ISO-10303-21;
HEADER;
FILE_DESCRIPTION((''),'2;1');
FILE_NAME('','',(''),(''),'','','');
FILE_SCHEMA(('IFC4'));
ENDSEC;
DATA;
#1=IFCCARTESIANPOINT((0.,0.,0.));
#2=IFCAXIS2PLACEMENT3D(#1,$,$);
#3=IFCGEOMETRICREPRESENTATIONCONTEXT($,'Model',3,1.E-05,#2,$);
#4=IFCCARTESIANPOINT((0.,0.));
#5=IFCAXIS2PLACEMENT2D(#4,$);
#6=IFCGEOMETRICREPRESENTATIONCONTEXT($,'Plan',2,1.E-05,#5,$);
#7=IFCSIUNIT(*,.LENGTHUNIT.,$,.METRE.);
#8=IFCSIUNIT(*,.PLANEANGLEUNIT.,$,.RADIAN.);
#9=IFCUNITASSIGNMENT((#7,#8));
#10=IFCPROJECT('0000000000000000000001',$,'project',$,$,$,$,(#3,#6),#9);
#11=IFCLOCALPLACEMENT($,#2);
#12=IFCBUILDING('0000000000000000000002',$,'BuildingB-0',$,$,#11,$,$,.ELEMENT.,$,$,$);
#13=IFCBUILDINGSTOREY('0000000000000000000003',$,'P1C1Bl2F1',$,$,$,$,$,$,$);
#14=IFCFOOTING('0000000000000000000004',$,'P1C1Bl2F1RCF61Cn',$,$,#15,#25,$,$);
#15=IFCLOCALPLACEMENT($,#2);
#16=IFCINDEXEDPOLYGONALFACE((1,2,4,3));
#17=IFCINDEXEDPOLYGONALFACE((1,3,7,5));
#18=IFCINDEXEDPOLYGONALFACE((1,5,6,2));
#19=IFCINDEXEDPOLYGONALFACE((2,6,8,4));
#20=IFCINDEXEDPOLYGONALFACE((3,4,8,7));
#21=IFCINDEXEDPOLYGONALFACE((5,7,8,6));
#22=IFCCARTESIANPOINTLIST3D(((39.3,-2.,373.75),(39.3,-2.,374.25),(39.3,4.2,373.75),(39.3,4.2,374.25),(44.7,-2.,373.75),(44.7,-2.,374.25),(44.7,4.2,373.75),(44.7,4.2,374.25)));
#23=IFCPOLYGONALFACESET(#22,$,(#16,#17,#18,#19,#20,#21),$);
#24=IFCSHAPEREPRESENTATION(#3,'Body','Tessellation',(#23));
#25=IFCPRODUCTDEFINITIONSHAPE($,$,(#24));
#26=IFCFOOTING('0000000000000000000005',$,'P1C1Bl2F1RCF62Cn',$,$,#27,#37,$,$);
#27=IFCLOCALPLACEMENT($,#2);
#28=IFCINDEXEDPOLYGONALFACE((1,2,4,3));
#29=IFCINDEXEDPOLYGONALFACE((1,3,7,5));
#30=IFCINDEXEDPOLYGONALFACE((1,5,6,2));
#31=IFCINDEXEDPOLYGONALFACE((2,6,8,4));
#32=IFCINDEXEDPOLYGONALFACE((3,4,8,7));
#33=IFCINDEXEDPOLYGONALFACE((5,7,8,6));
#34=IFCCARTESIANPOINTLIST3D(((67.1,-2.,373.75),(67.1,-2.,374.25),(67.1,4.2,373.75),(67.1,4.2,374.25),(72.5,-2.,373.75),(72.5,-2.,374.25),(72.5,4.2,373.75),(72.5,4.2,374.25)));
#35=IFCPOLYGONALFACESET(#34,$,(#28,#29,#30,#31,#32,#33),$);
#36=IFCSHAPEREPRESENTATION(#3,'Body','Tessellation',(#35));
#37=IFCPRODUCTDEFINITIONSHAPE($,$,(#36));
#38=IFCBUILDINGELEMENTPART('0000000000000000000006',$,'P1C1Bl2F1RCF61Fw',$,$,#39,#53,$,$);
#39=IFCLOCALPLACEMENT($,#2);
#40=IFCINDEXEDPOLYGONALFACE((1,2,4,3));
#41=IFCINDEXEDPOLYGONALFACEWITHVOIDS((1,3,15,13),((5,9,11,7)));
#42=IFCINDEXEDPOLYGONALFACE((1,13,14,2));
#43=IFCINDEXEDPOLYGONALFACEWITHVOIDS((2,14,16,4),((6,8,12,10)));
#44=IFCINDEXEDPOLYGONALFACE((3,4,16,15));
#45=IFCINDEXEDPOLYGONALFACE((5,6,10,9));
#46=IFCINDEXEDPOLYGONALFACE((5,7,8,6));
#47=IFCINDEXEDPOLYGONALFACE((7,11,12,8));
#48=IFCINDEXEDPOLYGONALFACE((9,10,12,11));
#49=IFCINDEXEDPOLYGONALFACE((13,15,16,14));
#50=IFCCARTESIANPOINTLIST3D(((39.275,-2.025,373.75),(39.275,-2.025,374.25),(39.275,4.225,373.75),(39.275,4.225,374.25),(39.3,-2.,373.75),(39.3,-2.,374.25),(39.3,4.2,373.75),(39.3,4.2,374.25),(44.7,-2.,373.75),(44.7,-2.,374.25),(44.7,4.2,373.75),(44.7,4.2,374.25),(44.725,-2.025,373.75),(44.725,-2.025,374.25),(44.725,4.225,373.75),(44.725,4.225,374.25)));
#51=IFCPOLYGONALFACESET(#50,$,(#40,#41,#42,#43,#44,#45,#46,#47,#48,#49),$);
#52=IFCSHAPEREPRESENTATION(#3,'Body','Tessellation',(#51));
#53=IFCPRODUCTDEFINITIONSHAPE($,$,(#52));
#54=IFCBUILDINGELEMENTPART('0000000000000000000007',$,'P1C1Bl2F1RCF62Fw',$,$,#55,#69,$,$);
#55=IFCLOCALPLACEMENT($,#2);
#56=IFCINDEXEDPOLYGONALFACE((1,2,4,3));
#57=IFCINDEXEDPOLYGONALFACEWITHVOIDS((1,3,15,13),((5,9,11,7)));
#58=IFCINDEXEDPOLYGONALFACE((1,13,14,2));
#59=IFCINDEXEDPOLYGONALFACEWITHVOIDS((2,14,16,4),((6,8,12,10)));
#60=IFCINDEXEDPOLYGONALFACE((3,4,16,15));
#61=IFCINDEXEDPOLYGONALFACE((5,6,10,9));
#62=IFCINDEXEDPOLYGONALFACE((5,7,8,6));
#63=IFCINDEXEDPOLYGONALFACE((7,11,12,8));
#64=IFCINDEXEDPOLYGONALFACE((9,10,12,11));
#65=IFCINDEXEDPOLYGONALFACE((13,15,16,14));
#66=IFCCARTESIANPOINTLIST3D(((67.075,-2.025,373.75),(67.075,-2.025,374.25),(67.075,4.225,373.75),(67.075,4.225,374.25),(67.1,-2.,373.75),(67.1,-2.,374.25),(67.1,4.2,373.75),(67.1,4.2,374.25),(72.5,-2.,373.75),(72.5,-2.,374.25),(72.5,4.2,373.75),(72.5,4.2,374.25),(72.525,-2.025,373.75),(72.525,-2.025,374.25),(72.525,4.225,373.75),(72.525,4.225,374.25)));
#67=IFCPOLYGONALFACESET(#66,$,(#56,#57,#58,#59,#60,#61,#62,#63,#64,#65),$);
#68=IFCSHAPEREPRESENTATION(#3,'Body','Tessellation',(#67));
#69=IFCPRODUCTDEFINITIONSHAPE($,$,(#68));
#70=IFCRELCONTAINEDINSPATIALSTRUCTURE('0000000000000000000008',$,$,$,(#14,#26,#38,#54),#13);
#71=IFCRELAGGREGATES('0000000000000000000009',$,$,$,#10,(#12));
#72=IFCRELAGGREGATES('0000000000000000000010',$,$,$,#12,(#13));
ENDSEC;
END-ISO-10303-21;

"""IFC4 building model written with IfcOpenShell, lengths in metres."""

from ifc_helpers import new_model, si_unit, origin, origin_2d, place, context, project, spatial, polyline, outline, extrude, element, save


model = new_model("IFC4")

# Units and contexts
model_context = context("Model", 3, precision=1e-05, world=origin())
plan_context = context("Plan", 2, precision=1e-05, world=origin_2d())
ifc_project = project(units=[si_unit("LENGTHUNIT", "METRE"), si_unit("PLANEANGLEUNIT", "RADIAN")], contexts=[model_context, plan_context])

# Building, storey
building_placement = place(None, origin())
building = spatial("IfcBuilding", under=ifc_project, at=building_placement, Name="BuildingB-0", CompositionType="ELEMENT")
storey = spatial("IfcBuildingStorey", under=building, Name="P1C1Bl2F1")

# Footings
element("IfcFooting", 1, inside=storey, Name="P1C1Bl2F1RCF61Cn", context=model_context, shape_type="SweptSolid", body=[
    extrude(outline(polyline([(44.7, -2.0, 373.75), (44.7, 4.2, 373.75), (39.3, 4.2, 373.75), (39.3, -2.0, 373.75), (44.7, -2.0, 373.75)])), None, (0.0, 0.0, 1.0), 0.5),
])
element("IfcFooting", 2, inside=storey, Name="P1C1Bl2F1RCF62Cn", context=model_context, shape_type="SweptSolid", body=[
    extrude(outline(polyline([(72.5, -2.0, 373.75), (72.5, 4.2, 373.75), (67.1, 4.2, 373.75), (67.1, -2.0, 373.75), (72.5, -2.0, 373.75)])), None, (0.0, 0.0, 1.0), 0.5),
])

# Building element part, opening
building_element_part_1 = element("IfcBuildingElementPart", 3, inside=storey, Name="P1C1Bl2F1RCF61Fw", context=model_context, shape_type="SweptSolid", body=[
    extrude(outline(polyline([(44.725, -2.025, 373.75), (44.725, 4.225, 373.75), (39.275, 4.225, 373.75), (39.275, -2.025, 373.75), (44.725, -2.025, 373.75)])), None, (0.0, 0.0, 1.0), 0.5),
])
element("IfcOpeningElement", 4, inside=storey, cuts=building_element_part_1, context=model_context, shape_type="SweptSolid", body=[
    extrude(outline(polyline([(44.7, -2.0, 373.75), (44.7, 4.2, 373.75), (39.3, 4.2, 373.75), (39.3, -2.0, 373.75), (44.7, -2.0, 373.75)])), None, (0.0, 0.0, 1.0), 0.5),
])

# Building element part, opening
building_element_part_2 = element("IfcBuildingElementPart", 5, inside=storey, Name="P1C1Bl2F1RCF62Fw", context=model_context, shape_type="SweptSolid", body=[
    extrude(outline(polyline([(72.525, -2.025, 373.75), (72.525, 4.225, 373.75), (67.075, 4.225, 373.75), (67.075, -2.025, 373.75), (72.525, -2.025, 373.75)])), None, (0.0, 0.0, 1.0), 0.5),
])
element("IfcOpeningElement", 6, inside=storey, cuts=building_element_part_2, context=model_context, shape_type="SweptSolid", body=[
    extrude(outline(polyline([(72.5, -2.0, 373.75), (72.5, 4.2, 373.75), (67.1, 4.2, 373.75), (67.1, -2.0, 373.75), (72.5, -2.0, 373.75)])), None, (0.0, 0.0, 1.0), 0.5),
])

save(model, "model.ifc")
